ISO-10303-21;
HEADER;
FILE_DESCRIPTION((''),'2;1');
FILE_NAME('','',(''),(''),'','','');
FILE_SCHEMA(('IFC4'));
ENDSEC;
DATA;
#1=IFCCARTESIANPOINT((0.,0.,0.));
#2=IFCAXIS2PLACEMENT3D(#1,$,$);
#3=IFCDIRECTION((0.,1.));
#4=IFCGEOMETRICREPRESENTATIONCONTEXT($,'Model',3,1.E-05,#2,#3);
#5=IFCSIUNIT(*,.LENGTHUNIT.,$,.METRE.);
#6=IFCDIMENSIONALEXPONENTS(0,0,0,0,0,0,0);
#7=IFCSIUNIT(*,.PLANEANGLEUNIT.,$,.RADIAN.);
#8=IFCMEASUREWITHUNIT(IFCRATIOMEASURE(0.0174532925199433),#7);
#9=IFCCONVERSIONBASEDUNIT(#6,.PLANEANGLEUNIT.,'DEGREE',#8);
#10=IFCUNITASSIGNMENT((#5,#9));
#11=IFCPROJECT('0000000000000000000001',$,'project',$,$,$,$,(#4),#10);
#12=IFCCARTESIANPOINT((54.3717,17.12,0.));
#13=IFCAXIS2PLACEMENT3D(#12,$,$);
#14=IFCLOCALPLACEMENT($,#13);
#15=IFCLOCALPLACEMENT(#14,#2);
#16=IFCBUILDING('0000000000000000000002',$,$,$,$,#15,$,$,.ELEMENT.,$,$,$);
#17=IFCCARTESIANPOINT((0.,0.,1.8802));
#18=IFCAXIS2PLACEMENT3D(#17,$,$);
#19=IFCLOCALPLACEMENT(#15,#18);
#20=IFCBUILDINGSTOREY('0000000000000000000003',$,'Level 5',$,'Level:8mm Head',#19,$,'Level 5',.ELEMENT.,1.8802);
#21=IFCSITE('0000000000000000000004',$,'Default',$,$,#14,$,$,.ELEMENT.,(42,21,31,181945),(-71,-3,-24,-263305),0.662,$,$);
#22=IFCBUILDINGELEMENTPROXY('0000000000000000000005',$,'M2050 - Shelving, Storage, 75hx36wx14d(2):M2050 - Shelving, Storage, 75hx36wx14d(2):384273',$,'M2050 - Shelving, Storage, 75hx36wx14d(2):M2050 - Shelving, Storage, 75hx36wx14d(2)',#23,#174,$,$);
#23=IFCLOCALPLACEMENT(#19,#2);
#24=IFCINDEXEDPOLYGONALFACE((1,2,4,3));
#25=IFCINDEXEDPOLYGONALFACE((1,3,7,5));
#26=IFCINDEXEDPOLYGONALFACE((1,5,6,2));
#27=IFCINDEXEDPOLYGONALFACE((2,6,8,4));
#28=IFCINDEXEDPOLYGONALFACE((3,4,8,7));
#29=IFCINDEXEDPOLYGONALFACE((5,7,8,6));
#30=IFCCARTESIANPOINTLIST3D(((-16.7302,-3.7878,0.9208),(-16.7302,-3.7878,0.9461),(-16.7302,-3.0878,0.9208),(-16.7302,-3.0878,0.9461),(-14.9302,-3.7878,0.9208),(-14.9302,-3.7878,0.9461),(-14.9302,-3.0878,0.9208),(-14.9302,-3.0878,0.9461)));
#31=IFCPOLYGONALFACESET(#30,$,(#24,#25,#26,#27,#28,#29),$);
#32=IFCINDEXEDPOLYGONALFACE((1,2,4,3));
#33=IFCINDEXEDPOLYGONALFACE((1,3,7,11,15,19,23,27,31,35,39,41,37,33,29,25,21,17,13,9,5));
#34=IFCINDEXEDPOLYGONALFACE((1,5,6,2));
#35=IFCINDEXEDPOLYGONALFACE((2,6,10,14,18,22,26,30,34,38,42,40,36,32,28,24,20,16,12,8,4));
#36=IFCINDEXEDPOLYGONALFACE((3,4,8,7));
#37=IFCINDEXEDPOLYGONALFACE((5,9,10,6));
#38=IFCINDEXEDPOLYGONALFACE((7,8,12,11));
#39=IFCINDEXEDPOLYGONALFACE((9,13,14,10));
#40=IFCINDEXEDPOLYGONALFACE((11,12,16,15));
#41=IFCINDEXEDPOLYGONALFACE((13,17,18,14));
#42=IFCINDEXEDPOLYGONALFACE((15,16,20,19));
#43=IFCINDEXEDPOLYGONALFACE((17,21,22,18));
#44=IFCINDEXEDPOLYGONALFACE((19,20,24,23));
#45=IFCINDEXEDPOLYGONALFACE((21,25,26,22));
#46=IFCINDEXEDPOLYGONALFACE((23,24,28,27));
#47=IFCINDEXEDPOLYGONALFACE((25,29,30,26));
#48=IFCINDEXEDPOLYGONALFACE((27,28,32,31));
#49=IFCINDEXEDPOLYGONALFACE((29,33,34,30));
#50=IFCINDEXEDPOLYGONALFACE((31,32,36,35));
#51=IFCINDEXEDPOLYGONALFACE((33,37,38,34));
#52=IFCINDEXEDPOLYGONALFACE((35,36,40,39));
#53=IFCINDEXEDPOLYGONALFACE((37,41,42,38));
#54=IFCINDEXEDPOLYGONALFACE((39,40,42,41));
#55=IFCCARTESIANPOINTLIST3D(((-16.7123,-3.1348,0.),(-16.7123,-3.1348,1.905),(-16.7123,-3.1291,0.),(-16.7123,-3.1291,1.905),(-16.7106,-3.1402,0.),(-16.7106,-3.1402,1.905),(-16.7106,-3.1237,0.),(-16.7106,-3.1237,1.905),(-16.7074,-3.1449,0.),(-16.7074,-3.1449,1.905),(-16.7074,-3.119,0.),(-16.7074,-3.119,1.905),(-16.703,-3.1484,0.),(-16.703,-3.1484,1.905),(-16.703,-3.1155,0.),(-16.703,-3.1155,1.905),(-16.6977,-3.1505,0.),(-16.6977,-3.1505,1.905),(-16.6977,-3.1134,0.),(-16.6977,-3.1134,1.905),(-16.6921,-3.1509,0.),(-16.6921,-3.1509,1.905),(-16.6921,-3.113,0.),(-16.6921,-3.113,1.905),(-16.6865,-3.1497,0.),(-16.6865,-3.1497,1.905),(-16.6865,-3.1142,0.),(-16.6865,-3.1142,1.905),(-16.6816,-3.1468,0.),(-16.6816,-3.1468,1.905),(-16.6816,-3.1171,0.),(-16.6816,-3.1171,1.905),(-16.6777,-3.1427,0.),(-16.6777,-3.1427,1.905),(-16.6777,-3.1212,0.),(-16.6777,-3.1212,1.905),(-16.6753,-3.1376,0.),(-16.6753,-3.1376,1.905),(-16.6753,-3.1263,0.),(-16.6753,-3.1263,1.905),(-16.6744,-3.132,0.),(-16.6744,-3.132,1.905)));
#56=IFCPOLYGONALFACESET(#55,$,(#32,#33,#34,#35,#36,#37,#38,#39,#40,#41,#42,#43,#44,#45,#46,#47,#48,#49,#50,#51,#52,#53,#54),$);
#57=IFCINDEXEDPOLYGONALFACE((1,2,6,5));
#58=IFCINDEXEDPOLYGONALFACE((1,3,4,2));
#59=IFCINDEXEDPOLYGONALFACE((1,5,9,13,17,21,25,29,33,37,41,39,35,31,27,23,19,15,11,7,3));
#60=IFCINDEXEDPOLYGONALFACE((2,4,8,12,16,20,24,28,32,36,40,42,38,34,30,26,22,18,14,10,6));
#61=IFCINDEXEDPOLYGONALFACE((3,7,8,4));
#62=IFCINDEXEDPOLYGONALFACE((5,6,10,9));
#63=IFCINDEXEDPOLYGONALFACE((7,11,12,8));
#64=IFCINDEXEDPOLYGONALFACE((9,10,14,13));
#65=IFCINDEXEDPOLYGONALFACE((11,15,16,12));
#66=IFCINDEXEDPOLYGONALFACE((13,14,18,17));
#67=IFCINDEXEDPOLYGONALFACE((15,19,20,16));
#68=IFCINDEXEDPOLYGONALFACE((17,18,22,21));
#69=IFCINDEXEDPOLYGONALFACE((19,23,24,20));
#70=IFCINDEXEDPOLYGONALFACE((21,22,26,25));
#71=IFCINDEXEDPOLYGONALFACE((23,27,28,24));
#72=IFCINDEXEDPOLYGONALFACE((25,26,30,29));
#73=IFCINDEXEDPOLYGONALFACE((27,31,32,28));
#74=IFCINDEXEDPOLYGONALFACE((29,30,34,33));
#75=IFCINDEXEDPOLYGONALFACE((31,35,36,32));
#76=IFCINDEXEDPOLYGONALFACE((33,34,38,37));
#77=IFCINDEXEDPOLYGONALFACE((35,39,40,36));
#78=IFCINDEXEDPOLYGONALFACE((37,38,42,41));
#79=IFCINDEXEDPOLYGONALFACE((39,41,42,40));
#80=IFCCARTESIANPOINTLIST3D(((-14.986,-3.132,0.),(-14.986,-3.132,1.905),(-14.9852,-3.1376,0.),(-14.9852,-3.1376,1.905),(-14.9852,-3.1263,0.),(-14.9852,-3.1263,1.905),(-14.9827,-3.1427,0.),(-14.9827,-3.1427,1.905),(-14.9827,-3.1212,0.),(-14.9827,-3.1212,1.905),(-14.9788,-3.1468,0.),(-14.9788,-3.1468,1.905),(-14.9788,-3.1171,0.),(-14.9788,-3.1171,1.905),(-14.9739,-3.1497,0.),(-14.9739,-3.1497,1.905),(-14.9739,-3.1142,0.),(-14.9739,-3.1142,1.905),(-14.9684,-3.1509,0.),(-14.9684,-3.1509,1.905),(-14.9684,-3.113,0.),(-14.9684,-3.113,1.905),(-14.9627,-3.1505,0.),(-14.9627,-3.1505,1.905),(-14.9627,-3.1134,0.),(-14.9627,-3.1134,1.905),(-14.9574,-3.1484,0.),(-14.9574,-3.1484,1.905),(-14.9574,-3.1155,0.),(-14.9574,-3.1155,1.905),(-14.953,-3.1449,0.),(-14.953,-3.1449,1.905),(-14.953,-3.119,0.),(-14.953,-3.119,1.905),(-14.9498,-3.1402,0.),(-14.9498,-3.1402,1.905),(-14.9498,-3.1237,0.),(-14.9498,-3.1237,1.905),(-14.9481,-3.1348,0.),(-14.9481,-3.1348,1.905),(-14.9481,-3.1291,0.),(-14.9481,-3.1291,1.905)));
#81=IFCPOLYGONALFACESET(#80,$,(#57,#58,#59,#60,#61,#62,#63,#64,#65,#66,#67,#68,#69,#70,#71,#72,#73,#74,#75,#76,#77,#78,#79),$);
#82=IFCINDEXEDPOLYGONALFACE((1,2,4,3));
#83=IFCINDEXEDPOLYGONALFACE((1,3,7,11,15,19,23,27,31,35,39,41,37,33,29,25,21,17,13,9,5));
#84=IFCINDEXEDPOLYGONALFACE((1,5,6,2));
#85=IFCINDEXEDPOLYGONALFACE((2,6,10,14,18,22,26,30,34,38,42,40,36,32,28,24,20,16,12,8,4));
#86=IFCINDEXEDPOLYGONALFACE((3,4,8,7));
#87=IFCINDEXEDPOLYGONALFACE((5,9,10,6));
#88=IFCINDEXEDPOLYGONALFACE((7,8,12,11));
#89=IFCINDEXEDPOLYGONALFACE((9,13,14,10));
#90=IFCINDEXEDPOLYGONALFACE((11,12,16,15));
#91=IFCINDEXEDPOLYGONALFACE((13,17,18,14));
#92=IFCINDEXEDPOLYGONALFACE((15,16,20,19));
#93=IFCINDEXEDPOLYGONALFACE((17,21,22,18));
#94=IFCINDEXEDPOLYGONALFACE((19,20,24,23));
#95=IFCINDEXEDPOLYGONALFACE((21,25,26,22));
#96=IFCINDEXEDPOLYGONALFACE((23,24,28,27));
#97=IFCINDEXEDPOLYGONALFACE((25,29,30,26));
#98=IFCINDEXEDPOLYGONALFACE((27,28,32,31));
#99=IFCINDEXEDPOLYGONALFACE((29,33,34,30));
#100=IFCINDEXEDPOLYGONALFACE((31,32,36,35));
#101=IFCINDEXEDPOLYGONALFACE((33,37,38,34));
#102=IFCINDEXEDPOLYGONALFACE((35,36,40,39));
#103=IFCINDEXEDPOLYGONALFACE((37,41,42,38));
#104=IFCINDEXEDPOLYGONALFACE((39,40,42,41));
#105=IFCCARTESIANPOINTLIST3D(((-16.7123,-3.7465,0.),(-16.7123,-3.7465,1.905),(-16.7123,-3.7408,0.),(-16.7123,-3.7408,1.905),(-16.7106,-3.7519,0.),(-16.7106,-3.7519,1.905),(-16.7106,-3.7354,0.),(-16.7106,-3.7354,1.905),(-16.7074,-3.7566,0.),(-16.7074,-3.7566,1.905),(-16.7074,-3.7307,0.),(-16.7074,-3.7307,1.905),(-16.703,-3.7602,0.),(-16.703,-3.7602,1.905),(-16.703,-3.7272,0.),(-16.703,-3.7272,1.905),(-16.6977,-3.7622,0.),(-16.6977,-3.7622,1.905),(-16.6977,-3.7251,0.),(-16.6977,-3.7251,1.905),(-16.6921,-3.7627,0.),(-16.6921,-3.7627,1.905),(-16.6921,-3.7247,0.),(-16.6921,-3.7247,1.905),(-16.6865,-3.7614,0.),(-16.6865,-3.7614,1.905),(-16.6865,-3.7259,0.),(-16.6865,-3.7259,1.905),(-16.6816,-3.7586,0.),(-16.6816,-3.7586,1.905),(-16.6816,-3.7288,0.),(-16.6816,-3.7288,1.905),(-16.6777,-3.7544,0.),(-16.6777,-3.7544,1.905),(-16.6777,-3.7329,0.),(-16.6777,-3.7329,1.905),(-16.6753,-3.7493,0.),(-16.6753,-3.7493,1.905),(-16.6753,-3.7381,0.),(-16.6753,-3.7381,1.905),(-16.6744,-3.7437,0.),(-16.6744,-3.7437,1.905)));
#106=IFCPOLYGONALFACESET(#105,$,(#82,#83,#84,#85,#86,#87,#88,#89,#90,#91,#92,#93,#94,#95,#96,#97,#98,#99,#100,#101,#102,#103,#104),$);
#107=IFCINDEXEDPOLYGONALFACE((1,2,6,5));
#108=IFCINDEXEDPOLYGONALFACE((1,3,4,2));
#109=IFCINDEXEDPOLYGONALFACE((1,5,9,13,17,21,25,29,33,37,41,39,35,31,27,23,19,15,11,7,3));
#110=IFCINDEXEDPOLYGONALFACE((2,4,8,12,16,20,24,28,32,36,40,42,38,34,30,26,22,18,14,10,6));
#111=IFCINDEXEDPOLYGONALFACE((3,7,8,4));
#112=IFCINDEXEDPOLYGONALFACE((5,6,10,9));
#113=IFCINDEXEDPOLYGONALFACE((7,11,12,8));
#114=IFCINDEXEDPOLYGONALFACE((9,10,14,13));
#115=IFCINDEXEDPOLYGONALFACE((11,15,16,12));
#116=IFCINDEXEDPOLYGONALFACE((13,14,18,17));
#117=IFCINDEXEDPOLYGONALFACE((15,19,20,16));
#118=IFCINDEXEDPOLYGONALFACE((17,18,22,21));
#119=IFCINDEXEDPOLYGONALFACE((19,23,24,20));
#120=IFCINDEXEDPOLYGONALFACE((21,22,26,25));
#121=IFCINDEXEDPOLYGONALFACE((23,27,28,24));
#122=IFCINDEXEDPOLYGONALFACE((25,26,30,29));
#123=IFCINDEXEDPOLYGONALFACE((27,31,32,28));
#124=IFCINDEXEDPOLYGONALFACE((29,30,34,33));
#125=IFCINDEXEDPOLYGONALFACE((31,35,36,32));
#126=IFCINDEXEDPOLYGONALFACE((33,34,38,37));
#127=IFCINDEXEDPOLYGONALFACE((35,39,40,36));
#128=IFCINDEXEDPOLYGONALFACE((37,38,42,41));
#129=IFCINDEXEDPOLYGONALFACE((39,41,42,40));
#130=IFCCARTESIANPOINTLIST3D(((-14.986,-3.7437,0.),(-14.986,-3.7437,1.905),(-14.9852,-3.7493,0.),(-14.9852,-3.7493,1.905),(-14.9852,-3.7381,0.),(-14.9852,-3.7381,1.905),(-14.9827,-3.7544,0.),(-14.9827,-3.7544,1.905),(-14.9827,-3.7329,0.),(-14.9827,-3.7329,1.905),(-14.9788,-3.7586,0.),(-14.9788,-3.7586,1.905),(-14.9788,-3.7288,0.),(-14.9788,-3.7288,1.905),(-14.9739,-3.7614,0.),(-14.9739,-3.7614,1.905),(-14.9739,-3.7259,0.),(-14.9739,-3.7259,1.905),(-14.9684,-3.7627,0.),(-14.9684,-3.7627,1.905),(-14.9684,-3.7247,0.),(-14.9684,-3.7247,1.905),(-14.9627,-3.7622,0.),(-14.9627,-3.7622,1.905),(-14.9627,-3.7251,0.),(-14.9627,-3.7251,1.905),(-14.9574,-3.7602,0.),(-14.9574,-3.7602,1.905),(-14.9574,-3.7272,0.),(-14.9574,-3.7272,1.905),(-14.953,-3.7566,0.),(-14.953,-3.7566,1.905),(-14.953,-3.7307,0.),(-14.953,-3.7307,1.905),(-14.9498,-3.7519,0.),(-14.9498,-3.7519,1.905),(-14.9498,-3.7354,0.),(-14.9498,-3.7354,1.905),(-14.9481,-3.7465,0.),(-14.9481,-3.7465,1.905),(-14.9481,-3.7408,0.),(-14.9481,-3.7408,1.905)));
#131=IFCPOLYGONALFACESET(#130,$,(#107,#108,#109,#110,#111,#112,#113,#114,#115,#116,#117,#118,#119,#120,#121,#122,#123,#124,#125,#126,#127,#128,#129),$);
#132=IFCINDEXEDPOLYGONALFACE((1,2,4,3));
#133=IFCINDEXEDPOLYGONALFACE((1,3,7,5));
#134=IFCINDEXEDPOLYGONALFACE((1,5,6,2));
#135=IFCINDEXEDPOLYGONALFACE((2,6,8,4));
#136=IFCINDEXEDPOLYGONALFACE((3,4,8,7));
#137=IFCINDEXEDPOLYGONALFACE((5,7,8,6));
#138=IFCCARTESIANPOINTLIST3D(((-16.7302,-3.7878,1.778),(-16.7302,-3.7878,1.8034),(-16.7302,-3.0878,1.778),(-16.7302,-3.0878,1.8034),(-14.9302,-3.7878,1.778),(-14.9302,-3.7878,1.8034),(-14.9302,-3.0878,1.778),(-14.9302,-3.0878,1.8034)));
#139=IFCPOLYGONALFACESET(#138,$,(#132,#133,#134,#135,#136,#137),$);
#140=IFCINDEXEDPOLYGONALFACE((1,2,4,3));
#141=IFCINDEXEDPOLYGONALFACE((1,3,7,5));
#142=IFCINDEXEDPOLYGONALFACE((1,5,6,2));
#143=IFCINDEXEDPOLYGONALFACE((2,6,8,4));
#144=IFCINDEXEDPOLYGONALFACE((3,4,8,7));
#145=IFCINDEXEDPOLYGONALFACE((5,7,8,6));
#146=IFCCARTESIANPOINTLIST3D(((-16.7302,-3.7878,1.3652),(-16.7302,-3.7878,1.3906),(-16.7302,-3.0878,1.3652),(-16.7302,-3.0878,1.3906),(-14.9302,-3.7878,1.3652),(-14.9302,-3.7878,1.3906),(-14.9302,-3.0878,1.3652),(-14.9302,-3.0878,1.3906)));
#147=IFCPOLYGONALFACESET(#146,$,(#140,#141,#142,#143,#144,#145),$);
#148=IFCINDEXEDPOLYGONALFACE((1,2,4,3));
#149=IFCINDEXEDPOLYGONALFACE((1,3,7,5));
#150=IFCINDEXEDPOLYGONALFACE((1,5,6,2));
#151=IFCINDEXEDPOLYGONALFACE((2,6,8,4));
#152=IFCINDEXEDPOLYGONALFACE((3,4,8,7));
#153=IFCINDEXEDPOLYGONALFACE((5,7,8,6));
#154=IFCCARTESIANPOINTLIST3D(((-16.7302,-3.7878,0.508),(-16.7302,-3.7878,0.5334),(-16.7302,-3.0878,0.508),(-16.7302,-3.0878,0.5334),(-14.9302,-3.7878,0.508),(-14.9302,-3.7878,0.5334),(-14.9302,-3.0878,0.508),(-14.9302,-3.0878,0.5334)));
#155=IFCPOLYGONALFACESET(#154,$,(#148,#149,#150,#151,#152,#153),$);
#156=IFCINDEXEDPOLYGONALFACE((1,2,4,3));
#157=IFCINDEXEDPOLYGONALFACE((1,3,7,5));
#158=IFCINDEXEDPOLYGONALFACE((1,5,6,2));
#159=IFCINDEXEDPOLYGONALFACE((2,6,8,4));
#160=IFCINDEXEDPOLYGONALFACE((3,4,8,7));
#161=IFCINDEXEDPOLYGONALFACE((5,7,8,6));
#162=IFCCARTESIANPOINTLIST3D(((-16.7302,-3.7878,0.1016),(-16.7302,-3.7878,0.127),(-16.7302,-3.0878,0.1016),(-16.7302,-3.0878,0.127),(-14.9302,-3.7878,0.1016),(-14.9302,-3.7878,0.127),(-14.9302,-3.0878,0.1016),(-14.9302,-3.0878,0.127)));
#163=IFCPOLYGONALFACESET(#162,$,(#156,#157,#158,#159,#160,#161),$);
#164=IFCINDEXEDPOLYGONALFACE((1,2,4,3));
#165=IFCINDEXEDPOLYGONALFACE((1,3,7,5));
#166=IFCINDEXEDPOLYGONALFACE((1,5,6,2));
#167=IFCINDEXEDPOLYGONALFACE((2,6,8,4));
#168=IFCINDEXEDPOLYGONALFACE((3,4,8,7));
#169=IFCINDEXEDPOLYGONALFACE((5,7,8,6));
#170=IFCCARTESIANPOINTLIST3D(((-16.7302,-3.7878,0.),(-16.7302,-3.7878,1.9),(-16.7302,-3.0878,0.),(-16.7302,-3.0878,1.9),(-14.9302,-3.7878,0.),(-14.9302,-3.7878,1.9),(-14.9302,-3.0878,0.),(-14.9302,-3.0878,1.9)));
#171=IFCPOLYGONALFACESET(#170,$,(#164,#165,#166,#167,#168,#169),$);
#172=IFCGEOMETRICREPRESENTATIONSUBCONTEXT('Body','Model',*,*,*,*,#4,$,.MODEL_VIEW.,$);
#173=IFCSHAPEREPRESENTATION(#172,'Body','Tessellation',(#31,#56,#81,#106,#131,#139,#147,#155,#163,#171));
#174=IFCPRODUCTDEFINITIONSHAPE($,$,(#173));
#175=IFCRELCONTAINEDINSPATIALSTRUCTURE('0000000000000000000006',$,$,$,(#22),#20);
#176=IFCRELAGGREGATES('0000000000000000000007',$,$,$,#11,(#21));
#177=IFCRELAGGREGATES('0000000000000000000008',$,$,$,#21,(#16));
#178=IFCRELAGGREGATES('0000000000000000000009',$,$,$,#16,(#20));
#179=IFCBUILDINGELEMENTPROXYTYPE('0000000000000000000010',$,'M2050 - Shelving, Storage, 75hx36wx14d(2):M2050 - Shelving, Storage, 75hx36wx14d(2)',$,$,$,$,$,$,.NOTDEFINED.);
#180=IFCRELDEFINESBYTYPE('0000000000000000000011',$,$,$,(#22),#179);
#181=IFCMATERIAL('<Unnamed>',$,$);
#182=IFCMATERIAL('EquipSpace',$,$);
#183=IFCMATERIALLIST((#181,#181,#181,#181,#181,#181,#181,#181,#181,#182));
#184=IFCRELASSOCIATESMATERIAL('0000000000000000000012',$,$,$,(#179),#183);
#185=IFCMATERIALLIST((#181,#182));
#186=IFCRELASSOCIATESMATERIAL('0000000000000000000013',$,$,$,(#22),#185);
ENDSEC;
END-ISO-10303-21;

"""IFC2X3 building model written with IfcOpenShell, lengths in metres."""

from ifc_helpers import new_model, entity, si_unit, converted_unit, direction, frame, frame_2d, origin, origin_2d_with_axis, place, context, subcontext, project, spatial, rectangle, circle, extrude, source, transform, mapped, material, material_list, type_object, type_shapes, element, save


model = new_model("IFC2X3")

# Units and contexts
model_context = context("Model", 3, precision=1e-05, world=origin(), true_north=direction((0.0, 1.0)))
body_context = subcontext(model_context, "Body", "Model", "MODEL_VIEW")
ifc_project = project(units=[si_unit("LENGTHUNIT", "METRE"), converted_unit("PLANEANGLEUNIT", "DEGREE", entity("IfcRatioMeasure", 0.0174532925199433), si_unit("PLANEANGLEUNIT", "RADIAN"), dimensions=[0, 0, 0, 0, 0, 0, 0])], contexts=[model_context])

# Site, building, storey
site_placement = place(None, frame((54.3717, 17.12, 0.0)))
site = spatial("IfcSite", under=ifc_project, at=site_placement, Name="Default", CompositionType="ELEMENT", RefLatitude=(42, 21, 31, 181945), RefLongitude=(-71, -3, -24, -263305), RefElevation=0.662)
building_placement = place(site_placement, origin())
building = spatial("IfcBuilding", under=site, at=building_placement, CompositionType="ELEMENT")
storey_placement = place(building_placement, frame((0.0, 0.0, 1.8802)))
storey = spatial("IfcBuildingStorey", under=building, at=storey_placement, Name="Level 5", ObjectType="Level:8mm Head", LongName="Level 5", CompositionType="ELEMENT", Elevation=1.8802)

# Building element proxy
ifc_material_1 = material(Name="<Unnamed>")
ifc_material_2 = material(Name="EquipSpace")
ifc_material_list_1 = material_list([ifc_material_1, ifc_material_1, ifc_material_1, ifc_material_1, ifc_material_1, ifc_material_1, ifc_material_1, ifc_material_1, ifc_material_1, ifc_material_2])
building_element_proxy_type = type_object("IfcBuildingElementProxyType", Name="M2050 - Shelving, Storage, 75hx36wx14d(2):M2050 - Shelving, Storage, 75hx36wx14d(2)", PredefinedType="NOTDEFINED", material=ifc_material_list_1)
shared_shape = source(origin(), body_context, "Body", "SweptSolid", [
    extrude(rectangle(XDim=1.8, YDim=0.7, at=origin_2d_with_axis()), frame((0.0, 0.0, 0.9207), z_axis=(0.0, 0.0, 1.0), x_axis=(-1.0, 0.0, 0.0)), (0.0, 0.0, 1.0), 0.0254),
    extrude(circle(Radius=0.0191, at=origin_2d_with_axis()), frame((0.8633, -0.3059, 0.0), z_axis=(0.0, 0.0, 1.0), x_axis=(-1.0, 0.0, 0.0)), (0.0, 0.0, 1.0), 1.905),
    extrude(circle(Radius=0.0191, at=origin_2d_with_axis()), frame((-0.8633, -0.3059, 0.0)), (0.0, 0.0, 1.0), 1.905),
    extrude(circle(Radius=0.0191, at=origin_2d_with_axis()), frame((0.8633, 0.3059, 0.0), z_axis=(0.0, 0.0, 1.0), x_axis=(-1.0, 0.0, 0.0)), (0.0, 0.0, 1.0), 1.905),
    extrude(circle(Radius=0.0191, at=origin_2d_with_axis()), frame((-0.8633, 0.3059, 0.0)), (0.0, 0.0, 1.0), 1.905),
    extrude(rectangle(XDim=1.8, YDim=0.7, at=origin_2d_with_axis()), frame((0.0, 0.0, 1.778), z_axis=(0.0, 0.0, 1.0), x_axis=(-1.0, 0.0, 0.0)), (0.0, 0.0, 1.0), 0.0254),
    extrude(rectangle(XDim=1.8, YDim=0.7, at=origin_2d_with_axis()), frame((0.0, 0.0, 1.3653), z_axis=(0.0, 0.0, 1.0), x_axis=(-1.0, 0.0, 0.0)), (0.0, 0.0, 1.0), 0.0254),
    extrude(rectangle(XDim=1.8, YDim=0.7, at=origin_2d_with_axis()), frame((0.0, 0.0, 0.508), z_axis=(0.0, 0.0, 1.0), x_axis=(-1.0, 0.0, 0.0)), (0.0, 0.0, 1.0), 0.0254),
    extrude(rectangle(XDim=1.8, YDim=0.7, at=origin_2d_with_axis()), frame((0.0, 0.0, 0.1016), z_axis=(0.0, 0.0, 1.0), x_axis=(-1.0, 0.0, 0.0)), (0.0, 0.0, 1.0), 0.0254),
    extrude(rectangle(XDim=0.7, YDim=1.8, at=frame_2d((0.0, 0.18), x_axis=(1.0, 0.0))), frame((-0.18, 0.0, 0.0), z_axis=(0.0, 0.0, 1.0), x_axis=(0.0, -1.0, 0.0)), (0.0, 0.0, 1.0), 1.9),
])
type_shapes(building_element_proxy_type, [shared_shape])
ifc_material_list_2 = material_list([ifc_material_1, ifc_material_2])
proxy_1_placement = place(storey_placement, frame((-15.8302, -3.4378, 0.0), z_axis=(0.0, 0.0, 1.0), x_axis=(-1.0, 0.0, 0.0)))
element("IfcBuildingElementProxy", 1, at=proxy_1_placement, inside=storey, type_object=building_element_proxy_type, material=ifc_material_list_2, Name="M2050 - Shelving, Storage, 75hx36wx14d(2):M2050 - Shelving, Storage, 75hx36wx14d(2):384273", ObjectType="M2050 - Shelving, Storage, 75hx36wx14d(2):M2050 - Shelving, Storage, 75hx36wx14d(2)", context=body_context, shape_type="MappedRepresentation", body=[
    mapped(shared_shape, transform((0.0, 0.0, 0.0), scale=1.0)),
])

save(model, "model.ifc")
